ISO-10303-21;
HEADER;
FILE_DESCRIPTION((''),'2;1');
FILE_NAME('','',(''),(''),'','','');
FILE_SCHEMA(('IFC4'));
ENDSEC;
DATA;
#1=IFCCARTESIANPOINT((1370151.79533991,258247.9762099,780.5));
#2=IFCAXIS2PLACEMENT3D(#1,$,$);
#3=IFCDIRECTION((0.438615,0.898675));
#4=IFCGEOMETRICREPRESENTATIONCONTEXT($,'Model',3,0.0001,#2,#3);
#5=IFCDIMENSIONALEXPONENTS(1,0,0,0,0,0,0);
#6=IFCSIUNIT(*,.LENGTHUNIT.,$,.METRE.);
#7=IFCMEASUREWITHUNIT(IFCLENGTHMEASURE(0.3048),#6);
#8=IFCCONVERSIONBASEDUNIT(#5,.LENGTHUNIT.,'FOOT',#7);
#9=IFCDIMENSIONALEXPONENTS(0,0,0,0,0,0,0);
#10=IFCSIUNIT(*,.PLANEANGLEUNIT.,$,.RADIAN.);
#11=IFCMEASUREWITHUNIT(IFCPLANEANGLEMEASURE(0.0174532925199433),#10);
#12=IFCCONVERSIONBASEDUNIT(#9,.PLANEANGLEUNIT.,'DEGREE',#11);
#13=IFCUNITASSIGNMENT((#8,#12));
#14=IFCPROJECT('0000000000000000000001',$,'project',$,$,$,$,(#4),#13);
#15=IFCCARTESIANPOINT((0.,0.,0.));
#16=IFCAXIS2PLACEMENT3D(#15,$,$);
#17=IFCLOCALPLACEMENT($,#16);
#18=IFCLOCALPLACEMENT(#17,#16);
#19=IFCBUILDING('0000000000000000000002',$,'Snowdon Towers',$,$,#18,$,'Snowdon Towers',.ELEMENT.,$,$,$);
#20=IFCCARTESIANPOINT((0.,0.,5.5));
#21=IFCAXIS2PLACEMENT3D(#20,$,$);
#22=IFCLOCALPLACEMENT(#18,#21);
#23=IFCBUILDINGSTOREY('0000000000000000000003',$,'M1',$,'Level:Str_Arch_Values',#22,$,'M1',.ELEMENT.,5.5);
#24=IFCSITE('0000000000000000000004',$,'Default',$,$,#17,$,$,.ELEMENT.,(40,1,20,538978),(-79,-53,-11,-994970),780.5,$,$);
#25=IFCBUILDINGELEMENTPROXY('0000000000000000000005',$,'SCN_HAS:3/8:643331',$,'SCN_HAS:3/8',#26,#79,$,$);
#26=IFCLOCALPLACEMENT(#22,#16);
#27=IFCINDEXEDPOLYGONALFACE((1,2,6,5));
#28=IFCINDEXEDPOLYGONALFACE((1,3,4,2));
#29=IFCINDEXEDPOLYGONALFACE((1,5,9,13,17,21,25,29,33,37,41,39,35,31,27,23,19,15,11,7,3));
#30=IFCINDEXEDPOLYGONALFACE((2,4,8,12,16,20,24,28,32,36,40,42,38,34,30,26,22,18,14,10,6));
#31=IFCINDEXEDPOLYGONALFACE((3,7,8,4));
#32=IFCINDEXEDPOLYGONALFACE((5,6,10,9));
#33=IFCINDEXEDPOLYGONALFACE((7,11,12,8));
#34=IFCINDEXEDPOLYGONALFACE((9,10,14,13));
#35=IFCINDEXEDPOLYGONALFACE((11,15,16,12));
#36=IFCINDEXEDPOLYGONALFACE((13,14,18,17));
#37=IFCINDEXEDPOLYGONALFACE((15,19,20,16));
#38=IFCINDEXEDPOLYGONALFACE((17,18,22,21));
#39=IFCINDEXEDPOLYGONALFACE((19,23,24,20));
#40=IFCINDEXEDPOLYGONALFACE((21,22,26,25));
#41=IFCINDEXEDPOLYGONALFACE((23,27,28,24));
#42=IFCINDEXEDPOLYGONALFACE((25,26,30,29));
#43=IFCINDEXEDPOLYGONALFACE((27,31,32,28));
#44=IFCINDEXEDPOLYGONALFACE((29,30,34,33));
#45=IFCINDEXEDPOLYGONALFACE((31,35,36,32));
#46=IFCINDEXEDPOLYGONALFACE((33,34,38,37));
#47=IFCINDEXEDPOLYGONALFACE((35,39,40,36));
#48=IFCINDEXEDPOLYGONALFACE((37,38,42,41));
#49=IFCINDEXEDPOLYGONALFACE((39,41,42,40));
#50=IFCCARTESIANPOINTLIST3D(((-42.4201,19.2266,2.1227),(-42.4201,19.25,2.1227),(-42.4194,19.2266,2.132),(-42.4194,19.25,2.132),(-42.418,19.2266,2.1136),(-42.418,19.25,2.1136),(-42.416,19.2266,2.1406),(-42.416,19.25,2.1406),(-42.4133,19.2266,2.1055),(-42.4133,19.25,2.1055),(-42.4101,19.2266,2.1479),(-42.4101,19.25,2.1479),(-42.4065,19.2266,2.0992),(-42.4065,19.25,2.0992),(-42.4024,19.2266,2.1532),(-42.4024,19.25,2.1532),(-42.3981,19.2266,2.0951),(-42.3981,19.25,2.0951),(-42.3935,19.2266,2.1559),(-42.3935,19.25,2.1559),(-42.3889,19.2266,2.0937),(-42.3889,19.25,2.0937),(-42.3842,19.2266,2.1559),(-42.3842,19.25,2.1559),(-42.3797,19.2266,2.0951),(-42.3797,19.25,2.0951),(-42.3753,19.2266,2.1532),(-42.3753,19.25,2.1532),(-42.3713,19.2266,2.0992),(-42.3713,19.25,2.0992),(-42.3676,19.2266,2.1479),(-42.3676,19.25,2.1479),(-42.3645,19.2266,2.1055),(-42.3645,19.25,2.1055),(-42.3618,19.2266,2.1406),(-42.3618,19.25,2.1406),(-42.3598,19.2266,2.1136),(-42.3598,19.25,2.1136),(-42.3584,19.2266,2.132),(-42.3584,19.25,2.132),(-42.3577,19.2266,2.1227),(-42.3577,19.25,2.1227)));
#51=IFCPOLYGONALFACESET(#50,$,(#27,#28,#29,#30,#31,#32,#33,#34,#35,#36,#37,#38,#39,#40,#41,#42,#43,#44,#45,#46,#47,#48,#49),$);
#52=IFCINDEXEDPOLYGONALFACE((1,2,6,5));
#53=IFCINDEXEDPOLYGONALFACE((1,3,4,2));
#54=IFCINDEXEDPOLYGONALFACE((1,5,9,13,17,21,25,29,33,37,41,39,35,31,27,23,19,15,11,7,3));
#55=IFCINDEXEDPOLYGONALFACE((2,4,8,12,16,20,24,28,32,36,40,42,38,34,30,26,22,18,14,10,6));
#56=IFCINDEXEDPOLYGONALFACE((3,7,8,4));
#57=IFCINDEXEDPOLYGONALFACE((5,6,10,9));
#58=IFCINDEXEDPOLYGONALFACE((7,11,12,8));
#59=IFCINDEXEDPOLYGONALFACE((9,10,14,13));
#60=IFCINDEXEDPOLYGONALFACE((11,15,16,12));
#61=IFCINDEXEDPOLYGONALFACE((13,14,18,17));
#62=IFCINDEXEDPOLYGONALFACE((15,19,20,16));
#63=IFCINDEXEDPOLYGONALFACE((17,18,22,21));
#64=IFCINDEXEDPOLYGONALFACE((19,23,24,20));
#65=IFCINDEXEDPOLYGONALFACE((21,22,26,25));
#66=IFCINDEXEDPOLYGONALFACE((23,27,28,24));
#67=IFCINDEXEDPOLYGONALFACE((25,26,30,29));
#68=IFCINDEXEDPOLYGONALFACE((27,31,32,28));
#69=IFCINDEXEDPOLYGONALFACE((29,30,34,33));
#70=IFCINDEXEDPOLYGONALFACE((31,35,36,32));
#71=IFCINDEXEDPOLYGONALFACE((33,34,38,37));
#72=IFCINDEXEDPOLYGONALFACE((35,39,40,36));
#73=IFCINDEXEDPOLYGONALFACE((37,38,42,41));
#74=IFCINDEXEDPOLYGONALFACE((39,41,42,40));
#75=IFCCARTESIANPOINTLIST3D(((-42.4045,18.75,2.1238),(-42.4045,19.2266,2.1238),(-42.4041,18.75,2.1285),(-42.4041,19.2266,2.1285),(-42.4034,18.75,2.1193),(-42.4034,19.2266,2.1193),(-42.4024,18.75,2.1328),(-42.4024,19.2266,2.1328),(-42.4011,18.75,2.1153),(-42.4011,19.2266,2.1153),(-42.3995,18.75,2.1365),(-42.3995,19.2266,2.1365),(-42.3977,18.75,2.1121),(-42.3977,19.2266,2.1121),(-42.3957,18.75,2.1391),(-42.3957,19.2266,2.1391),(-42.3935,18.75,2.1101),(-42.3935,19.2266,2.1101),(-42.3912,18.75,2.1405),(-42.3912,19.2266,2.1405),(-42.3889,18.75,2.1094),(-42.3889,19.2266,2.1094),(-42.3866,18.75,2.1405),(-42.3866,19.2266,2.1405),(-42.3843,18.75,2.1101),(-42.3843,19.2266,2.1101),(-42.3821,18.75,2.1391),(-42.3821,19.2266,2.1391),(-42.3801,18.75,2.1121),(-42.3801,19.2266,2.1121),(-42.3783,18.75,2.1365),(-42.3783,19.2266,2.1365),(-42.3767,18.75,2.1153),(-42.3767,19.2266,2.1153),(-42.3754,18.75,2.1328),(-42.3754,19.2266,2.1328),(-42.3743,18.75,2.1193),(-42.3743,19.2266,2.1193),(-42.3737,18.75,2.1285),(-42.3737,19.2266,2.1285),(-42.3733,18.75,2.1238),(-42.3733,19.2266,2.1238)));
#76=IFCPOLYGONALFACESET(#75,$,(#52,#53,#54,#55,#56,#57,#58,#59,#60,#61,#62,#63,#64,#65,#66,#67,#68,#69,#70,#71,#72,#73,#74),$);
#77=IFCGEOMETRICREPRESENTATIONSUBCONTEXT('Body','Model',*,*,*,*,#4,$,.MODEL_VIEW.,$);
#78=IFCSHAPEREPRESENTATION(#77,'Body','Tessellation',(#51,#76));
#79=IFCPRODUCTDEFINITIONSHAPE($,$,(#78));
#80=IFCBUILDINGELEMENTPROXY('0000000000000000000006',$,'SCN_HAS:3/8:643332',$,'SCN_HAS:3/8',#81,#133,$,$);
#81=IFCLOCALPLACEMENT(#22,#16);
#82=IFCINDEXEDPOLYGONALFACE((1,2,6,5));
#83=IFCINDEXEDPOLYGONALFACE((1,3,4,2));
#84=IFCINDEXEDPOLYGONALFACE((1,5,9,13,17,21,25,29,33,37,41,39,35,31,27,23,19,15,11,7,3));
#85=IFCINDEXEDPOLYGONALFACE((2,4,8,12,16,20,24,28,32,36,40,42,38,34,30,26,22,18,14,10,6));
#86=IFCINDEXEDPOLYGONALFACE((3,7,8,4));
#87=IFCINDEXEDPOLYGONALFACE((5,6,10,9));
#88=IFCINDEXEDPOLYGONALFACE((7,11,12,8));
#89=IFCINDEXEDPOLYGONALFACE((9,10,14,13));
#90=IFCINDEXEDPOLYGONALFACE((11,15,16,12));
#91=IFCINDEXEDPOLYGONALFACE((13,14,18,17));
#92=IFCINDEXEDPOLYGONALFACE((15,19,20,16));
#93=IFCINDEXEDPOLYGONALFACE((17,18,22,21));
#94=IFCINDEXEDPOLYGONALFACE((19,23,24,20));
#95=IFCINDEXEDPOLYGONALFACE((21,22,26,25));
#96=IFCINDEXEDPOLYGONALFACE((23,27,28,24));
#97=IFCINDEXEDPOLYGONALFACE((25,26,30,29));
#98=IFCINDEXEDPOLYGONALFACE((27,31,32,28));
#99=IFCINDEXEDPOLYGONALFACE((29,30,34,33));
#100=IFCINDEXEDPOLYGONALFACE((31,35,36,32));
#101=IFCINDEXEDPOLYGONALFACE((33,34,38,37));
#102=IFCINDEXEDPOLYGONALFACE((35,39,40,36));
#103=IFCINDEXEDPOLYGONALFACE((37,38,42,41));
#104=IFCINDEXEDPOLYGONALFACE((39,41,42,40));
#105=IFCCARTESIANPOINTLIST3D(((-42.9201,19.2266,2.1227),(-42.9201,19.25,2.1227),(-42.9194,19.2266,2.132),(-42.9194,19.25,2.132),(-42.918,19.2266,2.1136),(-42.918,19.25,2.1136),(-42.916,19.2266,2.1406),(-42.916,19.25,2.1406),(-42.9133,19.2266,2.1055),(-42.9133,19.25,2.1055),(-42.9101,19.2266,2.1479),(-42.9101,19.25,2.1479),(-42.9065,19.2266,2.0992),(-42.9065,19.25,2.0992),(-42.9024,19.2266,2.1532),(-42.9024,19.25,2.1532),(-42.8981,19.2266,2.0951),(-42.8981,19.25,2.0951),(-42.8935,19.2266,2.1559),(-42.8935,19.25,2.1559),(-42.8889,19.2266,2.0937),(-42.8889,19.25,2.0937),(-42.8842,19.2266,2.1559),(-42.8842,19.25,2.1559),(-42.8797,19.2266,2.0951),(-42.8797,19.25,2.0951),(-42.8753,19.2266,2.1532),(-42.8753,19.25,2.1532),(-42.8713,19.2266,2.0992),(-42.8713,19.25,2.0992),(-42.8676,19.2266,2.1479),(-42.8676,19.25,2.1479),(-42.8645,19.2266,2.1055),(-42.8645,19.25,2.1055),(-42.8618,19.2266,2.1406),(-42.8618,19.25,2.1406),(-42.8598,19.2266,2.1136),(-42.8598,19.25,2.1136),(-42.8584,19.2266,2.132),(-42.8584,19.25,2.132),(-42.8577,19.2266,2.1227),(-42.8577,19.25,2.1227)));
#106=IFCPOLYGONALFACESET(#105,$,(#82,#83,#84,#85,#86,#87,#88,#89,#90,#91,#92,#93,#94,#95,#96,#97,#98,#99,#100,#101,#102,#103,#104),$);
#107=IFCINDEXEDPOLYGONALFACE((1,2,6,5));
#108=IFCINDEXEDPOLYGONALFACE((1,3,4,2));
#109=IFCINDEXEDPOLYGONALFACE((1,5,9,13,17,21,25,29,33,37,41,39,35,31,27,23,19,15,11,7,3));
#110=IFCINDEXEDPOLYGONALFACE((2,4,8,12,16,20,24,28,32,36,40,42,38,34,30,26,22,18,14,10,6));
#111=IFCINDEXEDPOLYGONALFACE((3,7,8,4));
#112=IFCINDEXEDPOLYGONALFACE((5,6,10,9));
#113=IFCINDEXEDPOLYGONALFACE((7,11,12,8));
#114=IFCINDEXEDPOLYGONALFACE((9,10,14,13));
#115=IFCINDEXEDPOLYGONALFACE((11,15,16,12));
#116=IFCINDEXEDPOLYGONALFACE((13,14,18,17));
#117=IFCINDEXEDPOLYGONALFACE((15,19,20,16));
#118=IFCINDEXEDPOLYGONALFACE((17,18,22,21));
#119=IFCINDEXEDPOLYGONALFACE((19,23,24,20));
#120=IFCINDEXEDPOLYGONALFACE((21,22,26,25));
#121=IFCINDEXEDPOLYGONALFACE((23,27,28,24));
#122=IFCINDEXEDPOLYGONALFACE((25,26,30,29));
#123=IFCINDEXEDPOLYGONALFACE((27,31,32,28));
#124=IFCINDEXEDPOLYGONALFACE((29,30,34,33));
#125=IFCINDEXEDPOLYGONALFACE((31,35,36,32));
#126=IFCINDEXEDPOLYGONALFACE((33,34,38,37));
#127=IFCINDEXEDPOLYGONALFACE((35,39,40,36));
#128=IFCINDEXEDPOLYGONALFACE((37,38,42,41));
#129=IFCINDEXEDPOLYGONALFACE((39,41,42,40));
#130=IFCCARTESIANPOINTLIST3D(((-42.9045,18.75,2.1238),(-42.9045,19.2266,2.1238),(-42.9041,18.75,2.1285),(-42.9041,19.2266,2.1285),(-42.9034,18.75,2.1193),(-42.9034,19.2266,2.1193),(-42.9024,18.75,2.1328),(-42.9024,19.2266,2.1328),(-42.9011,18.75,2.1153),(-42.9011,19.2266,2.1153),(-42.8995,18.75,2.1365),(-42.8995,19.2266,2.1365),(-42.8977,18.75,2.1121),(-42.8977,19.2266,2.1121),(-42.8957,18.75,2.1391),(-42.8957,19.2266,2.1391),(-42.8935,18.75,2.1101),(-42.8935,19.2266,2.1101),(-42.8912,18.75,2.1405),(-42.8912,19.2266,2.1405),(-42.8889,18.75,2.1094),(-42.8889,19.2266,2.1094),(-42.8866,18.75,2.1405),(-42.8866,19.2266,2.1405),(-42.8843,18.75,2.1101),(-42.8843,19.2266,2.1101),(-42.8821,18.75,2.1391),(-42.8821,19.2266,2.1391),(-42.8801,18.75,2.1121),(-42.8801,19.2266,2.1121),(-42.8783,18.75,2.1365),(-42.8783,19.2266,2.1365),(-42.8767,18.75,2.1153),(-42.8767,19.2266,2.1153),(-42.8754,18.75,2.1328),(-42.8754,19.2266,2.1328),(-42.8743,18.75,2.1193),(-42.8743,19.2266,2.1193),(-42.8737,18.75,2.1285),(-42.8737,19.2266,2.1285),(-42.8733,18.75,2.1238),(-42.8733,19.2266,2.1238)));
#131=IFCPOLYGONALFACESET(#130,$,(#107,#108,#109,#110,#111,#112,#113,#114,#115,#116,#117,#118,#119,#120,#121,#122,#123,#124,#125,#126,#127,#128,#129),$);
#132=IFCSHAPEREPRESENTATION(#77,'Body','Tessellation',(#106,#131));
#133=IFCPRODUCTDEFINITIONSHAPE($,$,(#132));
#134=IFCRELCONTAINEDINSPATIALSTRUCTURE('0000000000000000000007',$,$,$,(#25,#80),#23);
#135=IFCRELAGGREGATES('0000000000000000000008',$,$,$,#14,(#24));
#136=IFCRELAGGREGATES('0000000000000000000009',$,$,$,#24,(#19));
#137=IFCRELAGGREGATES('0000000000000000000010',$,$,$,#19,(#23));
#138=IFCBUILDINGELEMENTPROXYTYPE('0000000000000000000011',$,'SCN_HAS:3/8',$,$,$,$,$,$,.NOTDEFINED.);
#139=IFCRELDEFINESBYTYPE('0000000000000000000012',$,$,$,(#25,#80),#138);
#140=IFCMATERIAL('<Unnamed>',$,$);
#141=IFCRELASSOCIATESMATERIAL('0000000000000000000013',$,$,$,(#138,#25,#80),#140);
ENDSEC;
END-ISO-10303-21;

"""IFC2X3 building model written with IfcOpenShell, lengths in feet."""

from ifc_helpers import new_model, entity, si_unit, converted_unit, direction, frame, frame_2d, origin, place, context, subcontext, project, spatial, circle, extrude, source, transform, mapped, material, type_object, type_shapes, element, save


model = new_model("IFC2X3")

# Units and contexts
model_context = context("Model", 3, precision=0.0001, world=frame((1370151.79533991, 258247.9762099, 780.5)), true_north=direction((0.438615, 0.898675)))
body_context = subcontext(model_context, "Body", "Model", "MODEL_VIEW")
ifc_project = project(units=[converted_unit("LENGTHUNIT", "FOOT", entity("IfcLengthMeasure", 0.3048), si_unit("LENGTHUNIT", "METRE"), dimensions=[1, 0, 0, 0, 0, 0, 0]), converted_unit("PLANEANGLEUNIT", "DEGREE", entity("IfcPlaneAngleMeasure", 0.0174532925199433), si_unit("PLANEANGLEUNIT", "RADIAN"), dimensions=[0, 0, 0, 0, 0, 0, 0])], contexts=[model_context])

# Site, building, storey
site_placement = place(None, origin())
site = spatial("IfcSite", under=ifc_project, at=site_placement, Name="Default", CompositionType="ELEMENT", RefLatitude=(40, 1, 20, 538978), RefLongitude=(-79, -53, -11, -994970), RefElevation=780.5)
building_placement = place(site_placement, origin())
building = spatial("IfcBuilding", under=site, at=building_placement, Name="Snowdon Towers", LongName="Snowdon Towers", CompositionType="ELEMENT")
storey_placement = place(building_placement, frame((0.0, 0.0, 5.5)))
storey = spatial("IfcBuildingStorey", under=building, at=storey_placement, Name="M1", ObjectType="Level:Str_Arch_Values", LongName="M1", CompositionType="ELEMENT", Elevation=5.5)

# Building element proxies
ifc_material_1 = material(Name="<Unnamed>")
building_element_proxy_type = type_object("IfcBuildingElementProxyType", Name="SCN_HAS:3/8", PredefinedType="NOTDEFINED", material=ifc_material_1)
shared_shape = source(origin(), body_context, "Body", "SweptSolid", [
    extrude(circle(Radius=0.0312, at=frame_2d((0.0, 0.0), x_axis=(1.0, 0.0))), frame((0.0, 0.0, -0.5), z_axis=(0.0, 0.0, 1.0), x_axis=(0.0, -1.0, 0.0)), (0.0, 0.0, 1.0), 0.0234),
    extrude(circle(Radius=0.0156, at=frame_2d((0.0, 0.0), x_axis=(1.0, 0.0))), frame((0.0, 0.0, -0.4766), z_axis=(0.0, 0.0, 1.0), x_axis=(0.0, -1.0, 0.0)), (0.0, 0.0, 1.0), 0.4766),
])
type_shapes(building_element_proxy_type, [shared_shape])
for number, where, z_axis, x_axis, name in (
    (1, (-42.3889, 18.75, 2.125), (0.0, -1.0, 0.0), (1.0, 0.0, 0.0), "SCN_HAS:3/8:643331"),
    (2, (-42.8889, 18.75, 2.125), (0.0, -1.0, 0.0), (1.0, 0.0, 0.0), "SCN_HAS:3/8:643332"),
):
    element("IfcBuildingElementProxy", number, at=place(storey_placement, frame(where, z_axis=z_axis, x_axis=x_axis)), inside=storey, type_object=building_element_proxy_type, material=ifc_material_1, Name=name, ObjectType="SCN_HAS:3/8", context=body_context, shape_type="MappedRepresentation", body=[
        mapped(shared_shape, transform((0.0, 0.0, 0.0), scale=1.0)),
    ])

save(model, "model.ifc")
